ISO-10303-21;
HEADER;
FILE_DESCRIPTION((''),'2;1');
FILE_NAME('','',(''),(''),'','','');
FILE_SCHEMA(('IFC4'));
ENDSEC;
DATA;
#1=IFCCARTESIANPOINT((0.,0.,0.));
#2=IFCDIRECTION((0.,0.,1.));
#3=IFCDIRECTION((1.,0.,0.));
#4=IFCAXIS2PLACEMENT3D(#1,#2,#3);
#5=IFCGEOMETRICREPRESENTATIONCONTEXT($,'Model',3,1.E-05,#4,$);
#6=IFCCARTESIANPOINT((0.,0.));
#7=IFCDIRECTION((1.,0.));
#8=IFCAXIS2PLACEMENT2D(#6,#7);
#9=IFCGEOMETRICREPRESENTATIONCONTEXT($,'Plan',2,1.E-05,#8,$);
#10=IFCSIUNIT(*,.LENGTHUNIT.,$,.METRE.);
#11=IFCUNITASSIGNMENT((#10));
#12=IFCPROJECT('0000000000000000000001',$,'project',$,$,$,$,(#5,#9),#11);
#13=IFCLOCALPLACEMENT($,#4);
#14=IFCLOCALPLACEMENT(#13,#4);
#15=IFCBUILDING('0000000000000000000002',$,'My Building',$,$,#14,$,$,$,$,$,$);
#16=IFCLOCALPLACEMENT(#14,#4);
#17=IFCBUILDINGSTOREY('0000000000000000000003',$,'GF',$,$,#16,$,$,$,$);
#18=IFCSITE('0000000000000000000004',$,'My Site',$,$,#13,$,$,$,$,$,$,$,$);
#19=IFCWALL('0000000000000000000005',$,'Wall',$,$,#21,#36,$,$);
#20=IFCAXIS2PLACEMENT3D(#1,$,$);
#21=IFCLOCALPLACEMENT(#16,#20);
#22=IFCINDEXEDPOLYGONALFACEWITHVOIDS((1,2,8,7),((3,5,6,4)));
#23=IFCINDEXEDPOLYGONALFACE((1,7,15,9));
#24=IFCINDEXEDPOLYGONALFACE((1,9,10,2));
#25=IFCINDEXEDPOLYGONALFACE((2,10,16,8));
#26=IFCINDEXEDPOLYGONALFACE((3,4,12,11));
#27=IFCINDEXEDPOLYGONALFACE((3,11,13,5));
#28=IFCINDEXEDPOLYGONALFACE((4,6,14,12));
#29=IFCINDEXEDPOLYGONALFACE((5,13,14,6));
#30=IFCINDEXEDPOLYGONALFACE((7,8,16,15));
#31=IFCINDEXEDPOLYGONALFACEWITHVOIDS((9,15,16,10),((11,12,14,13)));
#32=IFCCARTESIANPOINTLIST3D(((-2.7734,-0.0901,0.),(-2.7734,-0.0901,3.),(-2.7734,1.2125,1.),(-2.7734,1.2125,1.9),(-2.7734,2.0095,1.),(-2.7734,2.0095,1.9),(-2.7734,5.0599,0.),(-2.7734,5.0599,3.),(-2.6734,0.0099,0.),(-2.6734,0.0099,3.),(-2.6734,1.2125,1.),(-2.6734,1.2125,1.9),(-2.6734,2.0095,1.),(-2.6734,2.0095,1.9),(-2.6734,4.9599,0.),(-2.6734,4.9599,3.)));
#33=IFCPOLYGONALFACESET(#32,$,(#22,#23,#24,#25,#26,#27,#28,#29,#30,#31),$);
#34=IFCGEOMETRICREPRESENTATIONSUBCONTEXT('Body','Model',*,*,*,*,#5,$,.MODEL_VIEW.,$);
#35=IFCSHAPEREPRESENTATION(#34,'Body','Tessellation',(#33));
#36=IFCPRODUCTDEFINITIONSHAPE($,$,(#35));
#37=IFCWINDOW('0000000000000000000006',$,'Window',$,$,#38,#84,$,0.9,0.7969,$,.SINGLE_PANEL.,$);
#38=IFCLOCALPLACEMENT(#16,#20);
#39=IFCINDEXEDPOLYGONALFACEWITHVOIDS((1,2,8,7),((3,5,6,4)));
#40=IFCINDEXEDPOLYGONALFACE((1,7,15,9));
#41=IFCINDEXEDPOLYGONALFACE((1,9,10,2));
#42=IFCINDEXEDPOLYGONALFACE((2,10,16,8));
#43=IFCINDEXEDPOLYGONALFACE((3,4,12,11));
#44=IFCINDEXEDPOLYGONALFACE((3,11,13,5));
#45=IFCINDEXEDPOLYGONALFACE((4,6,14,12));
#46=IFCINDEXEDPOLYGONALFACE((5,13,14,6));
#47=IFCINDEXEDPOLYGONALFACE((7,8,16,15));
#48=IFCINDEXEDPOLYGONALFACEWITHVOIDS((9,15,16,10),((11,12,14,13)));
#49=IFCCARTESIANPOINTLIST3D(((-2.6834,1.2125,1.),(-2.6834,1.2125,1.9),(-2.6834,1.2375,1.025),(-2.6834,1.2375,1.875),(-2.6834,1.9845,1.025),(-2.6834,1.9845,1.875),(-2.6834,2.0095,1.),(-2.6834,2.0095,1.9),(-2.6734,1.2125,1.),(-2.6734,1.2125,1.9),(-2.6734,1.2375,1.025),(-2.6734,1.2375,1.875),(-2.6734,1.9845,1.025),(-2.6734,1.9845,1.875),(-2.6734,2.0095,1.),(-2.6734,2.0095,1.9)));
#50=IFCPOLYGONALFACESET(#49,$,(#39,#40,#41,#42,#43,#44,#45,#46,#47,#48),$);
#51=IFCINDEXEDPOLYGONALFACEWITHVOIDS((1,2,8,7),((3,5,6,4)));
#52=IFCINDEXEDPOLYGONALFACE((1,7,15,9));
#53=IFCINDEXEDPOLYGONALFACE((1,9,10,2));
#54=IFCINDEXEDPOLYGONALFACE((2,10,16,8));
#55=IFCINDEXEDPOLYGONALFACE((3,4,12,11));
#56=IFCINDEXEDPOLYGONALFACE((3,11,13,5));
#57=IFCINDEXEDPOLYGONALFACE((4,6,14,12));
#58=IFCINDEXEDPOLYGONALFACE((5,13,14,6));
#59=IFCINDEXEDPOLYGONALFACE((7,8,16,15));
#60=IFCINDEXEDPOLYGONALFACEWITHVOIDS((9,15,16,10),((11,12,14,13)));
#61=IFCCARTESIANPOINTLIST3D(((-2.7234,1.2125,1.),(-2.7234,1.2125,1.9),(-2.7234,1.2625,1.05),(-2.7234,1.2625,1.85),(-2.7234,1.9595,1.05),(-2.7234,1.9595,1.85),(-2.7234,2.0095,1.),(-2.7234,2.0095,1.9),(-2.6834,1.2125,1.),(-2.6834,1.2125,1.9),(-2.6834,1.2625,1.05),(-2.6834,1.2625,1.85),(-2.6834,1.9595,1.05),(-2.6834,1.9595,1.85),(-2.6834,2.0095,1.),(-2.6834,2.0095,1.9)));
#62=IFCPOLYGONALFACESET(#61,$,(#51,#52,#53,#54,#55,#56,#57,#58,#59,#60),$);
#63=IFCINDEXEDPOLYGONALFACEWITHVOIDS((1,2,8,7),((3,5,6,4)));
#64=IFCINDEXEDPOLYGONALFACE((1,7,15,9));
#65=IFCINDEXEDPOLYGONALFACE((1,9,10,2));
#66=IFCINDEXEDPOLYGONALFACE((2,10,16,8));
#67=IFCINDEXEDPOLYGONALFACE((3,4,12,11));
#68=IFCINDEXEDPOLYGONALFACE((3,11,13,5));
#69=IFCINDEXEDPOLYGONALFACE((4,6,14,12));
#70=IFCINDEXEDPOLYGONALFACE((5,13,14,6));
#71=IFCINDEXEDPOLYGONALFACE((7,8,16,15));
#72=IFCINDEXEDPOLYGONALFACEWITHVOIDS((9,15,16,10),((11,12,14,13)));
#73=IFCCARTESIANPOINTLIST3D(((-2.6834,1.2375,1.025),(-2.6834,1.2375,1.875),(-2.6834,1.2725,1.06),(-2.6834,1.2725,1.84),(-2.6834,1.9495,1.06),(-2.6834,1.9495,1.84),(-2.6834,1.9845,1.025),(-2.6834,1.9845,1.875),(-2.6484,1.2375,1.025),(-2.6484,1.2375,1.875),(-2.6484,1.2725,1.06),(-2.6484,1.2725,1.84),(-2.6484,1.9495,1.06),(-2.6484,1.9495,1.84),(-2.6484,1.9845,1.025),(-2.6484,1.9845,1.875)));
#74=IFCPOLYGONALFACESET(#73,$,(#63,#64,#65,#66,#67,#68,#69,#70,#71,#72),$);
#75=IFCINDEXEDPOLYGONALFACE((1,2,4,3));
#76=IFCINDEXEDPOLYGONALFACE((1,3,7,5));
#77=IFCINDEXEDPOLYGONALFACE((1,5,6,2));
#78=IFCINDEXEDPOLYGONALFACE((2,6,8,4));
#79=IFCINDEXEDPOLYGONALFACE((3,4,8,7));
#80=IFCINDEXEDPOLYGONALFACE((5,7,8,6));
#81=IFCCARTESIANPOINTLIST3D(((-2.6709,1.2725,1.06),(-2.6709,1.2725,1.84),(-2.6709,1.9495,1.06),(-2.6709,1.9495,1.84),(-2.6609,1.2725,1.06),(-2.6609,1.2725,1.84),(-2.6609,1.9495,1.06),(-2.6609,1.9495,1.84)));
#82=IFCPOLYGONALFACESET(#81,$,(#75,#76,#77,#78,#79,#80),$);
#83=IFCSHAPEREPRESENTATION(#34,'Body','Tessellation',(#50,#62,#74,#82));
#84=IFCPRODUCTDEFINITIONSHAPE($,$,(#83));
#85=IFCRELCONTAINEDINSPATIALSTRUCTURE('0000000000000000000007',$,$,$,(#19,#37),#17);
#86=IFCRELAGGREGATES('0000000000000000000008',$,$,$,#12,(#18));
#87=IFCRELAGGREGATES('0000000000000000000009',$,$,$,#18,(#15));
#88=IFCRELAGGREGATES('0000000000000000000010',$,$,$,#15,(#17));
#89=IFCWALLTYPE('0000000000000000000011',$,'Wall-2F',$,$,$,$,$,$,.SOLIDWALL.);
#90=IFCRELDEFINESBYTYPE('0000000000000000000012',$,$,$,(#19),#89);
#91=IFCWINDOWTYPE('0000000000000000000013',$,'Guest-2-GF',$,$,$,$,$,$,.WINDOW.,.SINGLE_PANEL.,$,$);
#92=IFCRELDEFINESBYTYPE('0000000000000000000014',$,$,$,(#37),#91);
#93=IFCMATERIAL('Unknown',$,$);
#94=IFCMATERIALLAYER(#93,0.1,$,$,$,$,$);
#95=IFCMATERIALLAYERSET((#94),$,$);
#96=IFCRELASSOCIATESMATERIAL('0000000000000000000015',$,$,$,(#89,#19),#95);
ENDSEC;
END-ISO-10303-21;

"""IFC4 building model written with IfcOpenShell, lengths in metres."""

from ifc_helpers import new_model, entity, si_unit, frame, origin_with_axes, origin_2d_with_axis, place, context, subcontext, project, spatial, line, indexed_curve, outline, extrude, shape, source, transform, mapped, material, layer, layer_set, layer_usage, type_object, type_shapes, element, fill, save


model = new_model("IFC4")

# Units and contexts
model_context = context("Model", 3, precision=1e-05, world=origin_with_axes())
plan_context = context("Plan", 2, precision=1e-05, world=origin_2d_with_axis())
body_context_1 = subcontext(model_context, "Body", "Model", "MODEL_VIEW")
body_context_2 = subcontext(plan_context, "Body", "Plan", "PLAN_VIEW")
ifc_project = project(units=[si_unit("LENGTHUNIT", "METRE")], contexts=[model_context, plan_context])

# Site, building, storey
site_placement = place(None, origin_with_axes())
site = spatial("IfcSite", under=ifc_project, at=site_placement, Name="My Site")
building_placement = place(site_placement, origin_with_axes())
building = spatial("IfcBuilding", under=site, at=building_placement, Name="My Building")
storey_placement = place(building_placement, origin_with_axes())
storey = spatial("IfcBuildingStorey", under=building, at=storey_placement, Name="GF")

# Shared definitions
ifc_material = material(Name="Unknown")

# Shared definitions
ifc_layer_1 = layer(ifc_material, 0.1)
ifc_layer_set_1 = layer_set([ifc_layer_1])
wall_type = type_object("IfcWallType", Name="Wall-2F", PredefinedType="SOLIDWALL", material=ifc_layer_set_1)

# Wall, opening, window
ifc_layer_usage_1 = layer_usage(ifc_layer_set_1, "AXIS2", "POSITIVE", 0.0)
wall_1_placement = place(storey_placement, frame((-2.7734, 5.0599, 0.0), z_axis=(0.0, 0.0, 1.0), x_axis=(0.0, -1.0, 0.0)))
wall_1 = element("IfcWall", 1, at=wall_1_placement, inside=storey, type_object=wall_type, material=ifc_layer_usage_1, Name="Wall", context=body_context_1, shape_type="SweptSolid", body=[
    extrude(outline(indexed_curve([(0.0, 0.0), (0.1, 0.1), (5.05, 0.1), (5.15, 0.0)], segments=[line(1, 2, 3, 4, 1)])), origin_with_axes(), (0.0, 0.0, 1.0), 3.0),
])
shared_shape_1 = source(origin_with_axes(), body_context_1, "Body", "SweptSolid", [
    extrude(outline(indexed_curve([(0.0, 0.0), (0.7969, 0.0), (0.7969, 0.9), (0.0, 0.9)], segments=[line(1, 2, 3, 4, 1)])), frame((0.0, -0.6, 0.0), z_axis=(0.0, -1.0, 0.0), x_axis=(1.0, 0.0, 0.0)), (0.0, 0.0, -1.0), 1.2),
])
opening_1_placement = place(wall_1_placement, frame((3.0504, 0.0, 1.0), z_axis=(0.0, 0.0, 1.0), x_axis=(1.0, 0.0, 0.0)))
opening_1 = element("IfcOpeningElement", 2, at=opening_1_placement, cuts=wall_1, PredefinedType="OPENING", context=body_context_1, shape_type="MappedRepresentation", body=[
    mapped(shared_shape_1, transform((0.0, 0.0, 0.0), x_axis=(1.0, 0.0, 0.0), y_axis=(0.0, 1.0, 0.0), z_axis=(0.0, 0.0, 1.0), scale=1.0)),
])
window_type_1 = type_object("IfcWindowType", Name="Guest-2-GF", PartitioningType="SINGLE_PANEL", PredefinedType="WINDOW")
shared_shape_2 = source(origin_with_axes(), body_context_1, "Body", "SweptSolid", [
    extrude(outline(indexed_curve([(0.0, 0.0), (0.7969, 0.0), (0.7969, 0.9), (0.0, 0.9)], segments=[line(1, 2, 3, 4, 1)]), holes=[indexed_curve([(0.025, 0.025), (0.7719, 0.025), (0.7719, 0.875), (0.025, 0.875)], segments=[line(1, 2, 3, 4, 1)])]), frame((0.0, 0.09, 0.0), z_axis=(0.0, -1.0, 0.0), x_axis=(1.0, 0.0, 0.0)), (0.0, 0.0, -1.0), 0.01),
    extrude(outline(indexed_curve([(0.0, 0.0), (0.7969, 0.0), (0.7969, 0.9), (0.0, 0.9)], segments=[line(1, 2, 3, 4, 1)]), holes=[indexed_curve([(0.05, 0.05), (0.7469, 0.05), (0.7469, 0.85), (0.05, 0.85)], segments=[line(1, 2, 3, 4, 1)])]), frame((0.0, 0.05, 0.0), z_axis=(0.0, -1.0, 0.0), x_axis=(1.0, 0.0, 0.0)), (0.0, 0.0, -1.0), 0.04),
    extrude(outline(indexed_curve([(0.0, 0.0), (0.7469, 0.0), (0.7469, 0.85), (0.0, 0.85)], segments=[line(1, 2, 3, 4, 1)]), holes=[indexed_curve([(0.035, 0.035), (0.7119, 0.035), (0.7119, 0.815), (0.035, 0.815)], segments=[line(1, 2, 3, 4, 1)])]), frame((0.025, 0.09, 0.025), z_axis=(0.0, -1.0, 0.0), x_axis=(1.0, 0.0, 0.0)), (0.0, 0.0, -1.0), 0.035),
    extrude(outline(indexed_curve([(0.035, 0.035), (0.7119, 0.035), (0.7119, 0.815), (0.035, 0.815)], segments=[line(1, 2, 3, 4, 1)])), frame((0.025, 0.1025, 0.025), z_axis=(0.0, -1.0, 0.0), x_axis=(1.0, 0.0, 0.0)), (0.0, 0.0, -1.0), 0.01),
])
shared_shape_3 = source(origin_with_axes(), body_context_2, "Body", "Curve2D", [
    entity("IfcIndexedPolyCurve", entity("IfcCartesianPointList2D", [[0.05, 0.05], [0.7469, 0.05]])),
    entity("IfcIndexedPolyCurve", entity("IfcCartesianPointList2D", [[0.0, 0.1], [0.025, 0.1], [0.025, 0.09], [0.05, 0.09], [0.05, 0.05], [0.0, 0.05]]), [entity("IfcLineIndex", [1, 2, 3, 4, 5, 6, 1])]),
    entity("IfcIndexedPolyCurve", entity("IfcCartesianPointList2D", [[0.7969, 0.1], [0.7719, 0.1], [0.7719, 0.09], [0.7469, 0.09], [0.7469, 0.05], [0.7969, 0.05]]), [entity("IfcLineIndex", [1, 2, 3, 4, 5, 6, 1])]),
    entity("IfcIndexedPolyCurve", entity("IfcCartesianPointList2D", [[0.025, 0.09], [0.06, 0.09], [0.06, 0.125], [0.025, 0.125]]), [entity("IfcLineIndex", [1, 2, 3, 4, 1])]),
    entity("IfcIndexedPolyCurve", entity("IfcCartesianPointList2D", [[0.7719, 0.09], [0.7369, 0.09], [0.7369, 0.125], [0.7719, 0.125]]), [entity("IfcLineIndex", [1, 2, 3, 4, 1])]),
    entity("IfcIndexedPolyCurve", entity("IfcCartesianPointList2D", [[0.06, 0.09], [0.7369, 0.09]])),
    entity("IfcIndexedPolyCurve", entity("IfcCartesianPointList2D", [[0.06, 0.125], [0.7369, 0.125]])),
    entity("IfcIndexedPolyCurve", entity("IfcCartesianPointList2D", [[0.06, 0.1075], [0.7369, 0.1075]])),
])
type_shapes(window_type_1, [shared_shape_2, shared_shape_3])
window_1_placement = place(opening_1_placement, frame((0.0, 0.0, 0.0), z_axis=(0.0, 0.0, 1.0), x_axis=(1.0, 0.0, 0.0)))
window_1 = element("IfcWindow", 3, at=window_1_placement, inside=storey, type_object=window_type_1, Name="Window", OverallHeight=0.9, OverallWidth=0.7969, PartitioningType="SINGLE_PANEL", shapes=[
    shape(body_context_1, "Body", "MappedRepresentation", [mapped(shared_shape_2, transform((0.0, 0.0, 0.0), x_axis=(1.0, 0.0, 0.0), y_axis=(0.0, 1.0, 0.0), z_axis=(0.0, 0.0, 1.0), scale=1.0))]),
    shape(body_context_2, "Body", "MappedRepresentation", [mapped(shared_shape_3, transform((0.0, 0.0, 0.0), x_axis=(1.0, 0.0, 0.0), y_axis=(0.0, 1.0, 0.0), z_axis=(0.0, 0.0, 1.0), scale=1.0))]),
])
fill(opening_1, window_1)

save(model, "model.ifc")
